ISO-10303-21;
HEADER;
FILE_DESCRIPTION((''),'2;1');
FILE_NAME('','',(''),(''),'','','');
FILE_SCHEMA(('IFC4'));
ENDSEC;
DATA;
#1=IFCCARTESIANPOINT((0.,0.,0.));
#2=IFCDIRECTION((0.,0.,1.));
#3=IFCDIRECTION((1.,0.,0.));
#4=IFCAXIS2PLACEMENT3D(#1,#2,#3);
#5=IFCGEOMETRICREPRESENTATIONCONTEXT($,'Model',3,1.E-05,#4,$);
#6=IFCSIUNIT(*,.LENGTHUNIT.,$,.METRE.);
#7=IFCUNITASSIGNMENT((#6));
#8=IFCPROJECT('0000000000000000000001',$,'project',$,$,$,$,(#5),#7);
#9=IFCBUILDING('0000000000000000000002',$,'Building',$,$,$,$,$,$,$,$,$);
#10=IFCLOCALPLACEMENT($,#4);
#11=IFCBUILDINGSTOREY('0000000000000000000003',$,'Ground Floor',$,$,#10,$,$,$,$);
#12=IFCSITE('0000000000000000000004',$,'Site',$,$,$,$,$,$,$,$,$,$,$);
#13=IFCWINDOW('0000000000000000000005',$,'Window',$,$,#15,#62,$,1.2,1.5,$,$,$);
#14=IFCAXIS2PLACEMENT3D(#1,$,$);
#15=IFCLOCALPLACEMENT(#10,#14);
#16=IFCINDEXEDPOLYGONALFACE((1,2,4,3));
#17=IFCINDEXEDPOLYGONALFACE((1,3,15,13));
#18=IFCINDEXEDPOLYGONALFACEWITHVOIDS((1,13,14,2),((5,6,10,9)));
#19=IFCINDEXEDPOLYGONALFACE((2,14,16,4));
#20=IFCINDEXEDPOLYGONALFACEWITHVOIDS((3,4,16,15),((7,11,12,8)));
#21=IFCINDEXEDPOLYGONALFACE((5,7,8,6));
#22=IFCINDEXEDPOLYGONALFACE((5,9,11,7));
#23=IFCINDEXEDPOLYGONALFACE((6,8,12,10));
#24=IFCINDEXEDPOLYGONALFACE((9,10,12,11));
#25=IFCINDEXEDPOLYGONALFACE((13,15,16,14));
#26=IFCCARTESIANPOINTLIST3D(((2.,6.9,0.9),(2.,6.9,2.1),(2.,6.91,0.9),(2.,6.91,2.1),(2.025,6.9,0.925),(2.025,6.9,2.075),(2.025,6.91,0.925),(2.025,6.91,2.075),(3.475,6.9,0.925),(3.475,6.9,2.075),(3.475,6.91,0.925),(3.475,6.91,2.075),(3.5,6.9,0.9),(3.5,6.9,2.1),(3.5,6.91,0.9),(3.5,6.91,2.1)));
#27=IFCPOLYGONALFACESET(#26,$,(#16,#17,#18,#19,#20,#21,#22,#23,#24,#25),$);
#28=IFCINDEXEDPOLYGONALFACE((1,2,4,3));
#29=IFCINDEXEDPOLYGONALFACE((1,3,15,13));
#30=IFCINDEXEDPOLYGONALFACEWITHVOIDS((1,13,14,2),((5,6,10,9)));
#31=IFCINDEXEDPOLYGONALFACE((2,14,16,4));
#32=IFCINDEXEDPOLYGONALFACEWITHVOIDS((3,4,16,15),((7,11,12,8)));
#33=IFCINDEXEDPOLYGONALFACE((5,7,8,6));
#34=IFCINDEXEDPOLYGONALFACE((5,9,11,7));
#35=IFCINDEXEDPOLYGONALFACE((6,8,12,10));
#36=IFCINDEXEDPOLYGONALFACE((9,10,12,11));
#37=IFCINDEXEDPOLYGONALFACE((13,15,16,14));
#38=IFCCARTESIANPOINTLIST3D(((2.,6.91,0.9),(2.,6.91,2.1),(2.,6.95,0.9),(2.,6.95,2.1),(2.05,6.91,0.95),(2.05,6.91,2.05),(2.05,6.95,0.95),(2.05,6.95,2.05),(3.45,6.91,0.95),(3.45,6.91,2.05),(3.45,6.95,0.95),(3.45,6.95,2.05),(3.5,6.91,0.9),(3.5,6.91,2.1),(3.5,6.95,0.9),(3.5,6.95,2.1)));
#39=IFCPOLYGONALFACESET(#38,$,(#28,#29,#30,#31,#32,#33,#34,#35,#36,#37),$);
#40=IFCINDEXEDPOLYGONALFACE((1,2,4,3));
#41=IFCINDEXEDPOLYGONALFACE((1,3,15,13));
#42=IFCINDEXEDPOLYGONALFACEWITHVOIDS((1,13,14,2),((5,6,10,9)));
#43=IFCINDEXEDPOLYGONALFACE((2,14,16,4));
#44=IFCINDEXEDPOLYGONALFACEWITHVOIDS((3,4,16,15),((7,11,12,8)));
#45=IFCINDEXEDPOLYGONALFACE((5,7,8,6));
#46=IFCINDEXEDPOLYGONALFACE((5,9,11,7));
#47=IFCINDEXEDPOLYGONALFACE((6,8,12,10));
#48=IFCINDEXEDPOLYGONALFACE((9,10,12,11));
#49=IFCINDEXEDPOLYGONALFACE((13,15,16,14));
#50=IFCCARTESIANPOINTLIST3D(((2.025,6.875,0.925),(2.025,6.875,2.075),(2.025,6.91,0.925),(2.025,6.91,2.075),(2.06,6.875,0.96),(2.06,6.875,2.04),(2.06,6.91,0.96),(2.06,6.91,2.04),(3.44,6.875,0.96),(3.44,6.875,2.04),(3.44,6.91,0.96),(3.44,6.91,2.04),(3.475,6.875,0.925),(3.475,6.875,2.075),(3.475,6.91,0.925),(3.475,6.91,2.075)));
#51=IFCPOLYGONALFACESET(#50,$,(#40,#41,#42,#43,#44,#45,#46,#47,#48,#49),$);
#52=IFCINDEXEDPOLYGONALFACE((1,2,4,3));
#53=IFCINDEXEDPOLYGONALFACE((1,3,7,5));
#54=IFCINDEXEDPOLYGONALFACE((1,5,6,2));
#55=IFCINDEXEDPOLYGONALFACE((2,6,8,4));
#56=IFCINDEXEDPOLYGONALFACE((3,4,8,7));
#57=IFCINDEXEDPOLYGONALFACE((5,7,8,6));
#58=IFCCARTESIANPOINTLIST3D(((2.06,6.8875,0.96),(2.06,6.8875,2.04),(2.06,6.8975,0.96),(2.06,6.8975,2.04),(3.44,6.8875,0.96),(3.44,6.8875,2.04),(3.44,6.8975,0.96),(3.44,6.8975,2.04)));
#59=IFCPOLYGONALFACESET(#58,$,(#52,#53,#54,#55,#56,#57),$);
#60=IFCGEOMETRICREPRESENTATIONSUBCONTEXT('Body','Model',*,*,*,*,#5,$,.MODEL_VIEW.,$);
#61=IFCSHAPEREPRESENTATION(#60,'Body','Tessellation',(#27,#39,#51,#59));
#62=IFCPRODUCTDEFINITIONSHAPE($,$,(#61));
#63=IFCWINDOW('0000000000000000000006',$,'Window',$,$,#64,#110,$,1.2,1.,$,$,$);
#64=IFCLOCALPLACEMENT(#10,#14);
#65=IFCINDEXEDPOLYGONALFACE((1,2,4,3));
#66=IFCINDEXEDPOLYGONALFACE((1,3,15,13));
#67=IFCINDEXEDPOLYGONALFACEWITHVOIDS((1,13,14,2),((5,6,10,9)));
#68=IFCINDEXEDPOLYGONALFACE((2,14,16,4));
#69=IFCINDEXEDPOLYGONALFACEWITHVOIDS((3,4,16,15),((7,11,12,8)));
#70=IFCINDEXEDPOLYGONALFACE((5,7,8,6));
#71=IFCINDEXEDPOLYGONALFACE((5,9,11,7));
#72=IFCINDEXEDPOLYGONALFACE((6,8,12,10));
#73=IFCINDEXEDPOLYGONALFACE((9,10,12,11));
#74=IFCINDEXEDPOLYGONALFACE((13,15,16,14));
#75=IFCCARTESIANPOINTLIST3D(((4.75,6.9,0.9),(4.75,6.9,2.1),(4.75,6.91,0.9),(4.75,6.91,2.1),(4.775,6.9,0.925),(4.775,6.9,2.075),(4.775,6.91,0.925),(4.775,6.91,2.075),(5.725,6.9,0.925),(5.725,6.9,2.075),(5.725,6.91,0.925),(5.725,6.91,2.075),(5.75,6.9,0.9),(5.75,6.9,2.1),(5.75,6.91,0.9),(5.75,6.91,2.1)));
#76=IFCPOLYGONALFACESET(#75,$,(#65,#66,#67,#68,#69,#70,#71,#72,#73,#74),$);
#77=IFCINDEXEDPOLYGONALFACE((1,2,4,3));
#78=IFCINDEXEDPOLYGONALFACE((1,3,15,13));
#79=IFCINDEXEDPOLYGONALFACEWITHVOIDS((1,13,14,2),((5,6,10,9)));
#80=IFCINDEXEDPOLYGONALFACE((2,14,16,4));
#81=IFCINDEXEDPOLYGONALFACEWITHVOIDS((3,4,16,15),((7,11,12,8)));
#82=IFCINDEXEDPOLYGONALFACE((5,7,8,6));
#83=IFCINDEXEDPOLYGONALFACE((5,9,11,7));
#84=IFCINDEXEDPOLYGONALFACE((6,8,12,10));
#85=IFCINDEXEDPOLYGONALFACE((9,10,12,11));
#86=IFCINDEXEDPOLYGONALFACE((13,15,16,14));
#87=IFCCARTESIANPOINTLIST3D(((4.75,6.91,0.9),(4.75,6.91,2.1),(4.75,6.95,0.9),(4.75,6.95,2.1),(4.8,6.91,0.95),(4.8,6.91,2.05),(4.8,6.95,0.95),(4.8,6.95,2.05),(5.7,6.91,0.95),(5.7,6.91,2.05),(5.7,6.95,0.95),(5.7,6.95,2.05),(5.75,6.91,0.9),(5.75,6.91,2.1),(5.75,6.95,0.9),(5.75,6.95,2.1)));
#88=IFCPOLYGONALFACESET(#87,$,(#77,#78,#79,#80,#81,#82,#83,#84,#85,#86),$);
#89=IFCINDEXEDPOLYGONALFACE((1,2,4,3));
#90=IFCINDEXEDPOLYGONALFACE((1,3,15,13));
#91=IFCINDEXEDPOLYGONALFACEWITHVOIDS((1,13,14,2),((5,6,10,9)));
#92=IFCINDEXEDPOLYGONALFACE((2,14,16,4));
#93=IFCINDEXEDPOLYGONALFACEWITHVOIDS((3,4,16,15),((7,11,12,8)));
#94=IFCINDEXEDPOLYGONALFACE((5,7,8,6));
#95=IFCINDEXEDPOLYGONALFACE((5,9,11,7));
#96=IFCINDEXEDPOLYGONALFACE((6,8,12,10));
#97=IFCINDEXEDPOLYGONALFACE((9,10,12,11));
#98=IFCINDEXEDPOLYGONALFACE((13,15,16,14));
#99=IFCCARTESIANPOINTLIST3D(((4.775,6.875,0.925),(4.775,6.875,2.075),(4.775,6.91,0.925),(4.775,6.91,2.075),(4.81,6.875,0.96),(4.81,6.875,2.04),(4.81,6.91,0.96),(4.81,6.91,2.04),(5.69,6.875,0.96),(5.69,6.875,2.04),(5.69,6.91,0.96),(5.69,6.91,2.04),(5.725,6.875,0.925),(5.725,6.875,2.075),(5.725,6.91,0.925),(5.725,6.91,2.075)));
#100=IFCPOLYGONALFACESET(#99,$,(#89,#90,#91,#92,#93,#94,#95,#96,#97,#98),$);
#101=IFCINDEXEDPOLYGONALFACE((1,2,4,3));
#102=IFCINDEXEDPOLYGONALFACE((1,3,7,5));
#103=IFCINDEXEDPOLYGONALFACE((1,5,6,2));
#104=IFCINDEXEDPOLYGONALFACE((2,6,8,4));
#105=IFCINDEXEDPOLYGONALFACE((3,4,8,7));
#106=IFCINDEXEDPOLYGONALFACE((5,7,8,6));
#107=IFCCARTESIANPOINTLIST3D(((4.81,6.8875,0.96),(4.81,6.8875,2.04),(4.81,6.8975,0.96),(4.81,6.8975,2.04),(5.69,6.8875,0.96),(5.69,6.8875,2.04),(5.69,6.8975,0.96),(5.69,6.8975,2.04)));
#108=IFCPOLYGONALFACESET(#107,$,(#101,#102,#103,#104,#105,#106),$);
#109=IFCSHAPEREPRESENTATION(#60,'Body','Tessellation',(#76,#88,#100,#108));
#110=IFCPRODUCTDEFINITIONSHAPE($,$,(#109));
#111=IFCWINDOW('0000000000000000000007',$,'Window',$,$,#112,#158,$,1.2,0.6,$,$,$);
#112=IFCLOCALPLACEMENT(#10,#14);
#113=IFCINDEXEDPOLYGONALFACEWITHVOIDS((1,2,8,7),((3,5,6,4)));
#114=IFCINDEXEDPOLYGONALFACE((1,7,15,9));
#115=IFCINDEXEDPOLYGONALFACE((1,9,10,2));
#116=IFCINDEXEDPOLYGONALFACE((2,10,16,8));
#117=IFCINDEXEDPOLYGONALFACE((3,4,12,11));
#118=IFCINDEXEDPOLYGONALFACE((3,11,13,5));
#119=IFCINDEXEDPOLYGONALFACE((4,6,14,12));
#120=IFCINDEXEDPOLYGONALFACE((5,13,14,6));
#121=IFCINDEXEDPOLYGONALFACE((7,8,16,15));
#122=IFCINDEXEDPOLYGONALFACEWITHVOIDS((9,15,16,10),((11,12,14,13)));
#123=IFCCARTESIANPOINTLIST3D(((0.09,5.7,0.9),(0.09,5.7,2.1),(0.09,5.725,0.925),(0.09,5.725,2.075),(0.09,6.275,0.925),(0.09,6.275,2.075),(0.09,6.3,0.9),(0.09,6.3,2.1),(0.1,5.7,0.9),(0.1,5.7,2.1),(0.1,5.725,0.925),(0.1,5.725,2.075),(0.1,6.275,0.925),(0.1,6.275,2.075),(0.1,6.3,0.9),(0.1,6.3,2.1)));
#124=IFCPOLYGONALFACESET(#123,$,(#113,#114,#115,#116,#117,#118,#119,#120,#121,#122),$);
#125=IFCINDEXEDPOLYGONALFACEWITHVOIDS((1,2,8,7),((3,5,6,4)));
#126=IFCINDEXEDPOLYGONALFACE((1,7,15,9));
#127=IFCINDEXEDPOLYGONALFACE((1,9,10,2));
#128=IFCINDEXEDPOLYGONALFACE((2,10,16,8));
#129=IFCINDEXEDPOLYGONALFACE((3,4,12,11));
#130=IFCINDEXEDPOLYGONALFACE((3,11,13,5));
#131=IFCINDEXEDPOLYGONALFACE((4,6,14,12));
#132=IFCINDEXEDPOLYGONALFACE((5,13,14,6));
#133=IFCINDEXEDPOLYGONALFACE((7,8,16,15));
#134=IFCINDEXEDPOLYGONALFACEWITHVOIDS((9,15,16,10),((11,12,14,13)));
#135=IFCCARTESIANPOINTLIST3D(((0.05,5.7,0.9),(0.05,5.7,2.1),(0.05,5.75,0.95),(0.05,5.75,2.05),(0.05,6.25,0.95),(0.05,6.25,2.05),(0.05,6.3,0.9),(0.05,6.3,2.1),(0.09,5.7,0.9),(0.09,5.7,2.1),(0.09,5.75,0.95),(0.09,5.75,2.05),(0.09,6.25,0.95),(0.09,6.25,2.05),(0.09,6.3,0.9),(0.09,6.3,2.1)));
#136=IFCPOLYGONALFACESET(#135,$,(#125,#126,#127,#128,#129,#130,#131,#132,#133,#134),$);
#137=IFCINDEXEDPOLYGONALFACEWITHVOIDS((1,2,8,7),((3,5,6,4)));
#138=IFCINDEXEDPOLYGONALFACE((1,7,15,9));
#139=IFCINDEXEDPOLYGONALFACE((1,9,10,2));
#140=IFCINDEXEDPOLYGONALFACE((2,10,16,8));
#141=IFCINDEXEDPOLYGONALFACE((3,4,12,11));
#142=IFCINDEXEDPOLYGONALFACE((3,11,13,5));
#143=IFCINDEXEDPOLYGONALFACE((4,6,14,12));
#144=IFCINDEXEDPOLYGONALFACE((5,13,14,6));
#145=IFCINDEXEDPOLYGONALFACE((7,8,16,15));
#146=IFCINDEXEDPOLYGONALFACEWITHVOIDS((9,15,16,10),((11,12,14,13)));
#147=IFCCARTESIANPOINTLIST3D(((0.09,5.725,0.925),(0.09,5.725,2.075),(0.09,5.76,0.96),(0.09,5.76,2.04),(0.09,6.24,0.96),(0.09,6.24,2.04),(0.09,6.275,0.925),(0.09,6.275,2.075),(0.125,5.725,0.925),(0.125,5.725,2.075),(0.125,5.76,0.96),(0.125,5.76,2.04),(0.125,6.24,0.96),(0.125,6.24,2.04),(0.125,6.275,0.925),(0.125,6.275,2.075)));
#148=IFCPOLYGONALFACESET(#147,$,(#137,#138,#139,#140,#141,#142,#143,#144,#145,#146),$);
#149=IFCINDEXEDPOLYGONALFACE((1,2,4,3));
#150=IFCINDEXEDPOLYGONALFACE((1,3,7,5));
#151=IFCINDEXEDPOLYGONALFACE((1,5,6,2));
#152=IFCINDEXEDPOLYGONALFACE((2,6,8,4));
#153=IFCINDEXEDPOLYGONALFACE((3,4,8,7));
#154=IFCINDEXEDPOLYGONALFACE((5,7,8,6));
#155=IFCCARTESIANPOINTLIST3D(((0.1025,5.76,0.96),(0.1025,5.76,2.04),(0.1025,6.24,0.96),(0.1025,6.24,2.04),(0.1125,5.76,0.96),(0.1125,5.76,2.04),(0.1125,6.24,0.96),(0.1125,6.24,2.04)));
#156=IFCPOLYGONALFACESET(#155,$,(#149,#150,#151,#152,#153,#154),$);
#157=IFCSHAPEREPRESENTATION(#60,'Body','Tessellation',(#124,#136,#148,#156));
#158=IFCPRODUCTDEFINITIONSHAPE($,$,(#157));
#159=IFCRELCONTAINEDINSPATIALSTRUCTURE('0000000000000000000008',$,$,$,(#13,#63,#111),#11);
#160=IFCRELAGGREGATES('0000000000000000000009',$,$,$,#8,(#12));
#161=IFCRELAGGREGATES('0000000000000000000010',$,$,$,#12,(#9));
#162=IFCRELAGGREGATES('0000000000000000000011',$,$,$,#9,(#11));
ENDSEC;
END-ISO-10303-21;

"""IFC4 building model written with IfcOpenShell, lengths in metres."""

from ifc_helpers import new_model, si_unit, frame, origin_with_axes, place, context, subcontext, project, spatial, line, indexed_curve, outline, extrude, element, save


model = new_model("IFC4")

# Units and contexts
model_context = context("Model", 3, precision=1e-05, world=origin_with_axes())
body_context = subcontext(model_context, "Body", "Model", "MODEL_VIEW")
ifc_project = project(units=[si_unit("LENGTHUNIT", "METRE")], contexts=[model_context])

# Site, building, storey
site = spatial("IfcSite", under=ifc_project, Name="Site")
building = spatial("IfcBuilding", under=site, Name="Building")
storey_placement = place(None, origin_with_axes())
storey = spatial("IfcBuildingStorey", under=building, at=storey_placement, Name="Ground Floor")

# Windows
window_1_placement = place(storey_placement, frame((3.5, 7.0, 0.9), z_axis=(0.0, 0.0, 1.0), x_axis=(-1.0, 0.0, 0.0)))
element("IfcWindow", 1, at=window_1_placement, inside=storey, Name="Window", OverallHeight=1.2, OverallWidth=1.5, context=body_context, shape_type="SweptSolid", body=[
    extrude(outline(indexed_curve([(0.0, 0.0), (1.5, 0.0), (1.5, 1.2), (0.0, 1.2)], segments=[line(1, 2, 3, 4, 1)]), holes=[indexed_curve([(0.025, 0.025), (1.475, 0.025), (1.475, 1.175), (0.025, 1.175)], segments=[line(1, 2, 3, 4, 1)])]), frame((0.0, 0.09, 0.0), z_axis=(0.0, -1.0, 0.0), x_axis=(1.0, 0.0, 0.0)), (0.0, 0.0, -1.0), 0.01),
    extrude(outline(indexed_curve([(0.0, 0.0), (1.5, 0.0), (1.5, 1.2), (0.0, 1.2)], segments=[line(1, 2, 3, 4, 1)]), holes=[indexed_curve([(0.05, 0.05), (1.45, 0.05), (1.45, 1.15), (0.05, 1.15)], segments=[line(1, 2, 3, 4, 1)])]), frame((0.0, 0.05, 0.0), z_axis=(0.0, -1.0, 0.0), x_axis=(1.0, 0.0, 0.0)), (0.0, 0.0, -1.0), 0.04),
    extrude(outline(indexed_curve([(0.0, 0.0), (1.45, 0.0), (1.45, 1.15), (0.0, 1.15)], segments=[line(1, 2, 3, 4, 1)]), holes=[indexed_curve([(0.035, 0.035), (1.415, 0.035), (1.415, 1.115), (0.035, 1.115)], segments=[line(1, 2, 3, 4, 1)])]), frame((0.025, 0.09, 0.025), z_axis=(0.0, -1.0, 0.0), x_axis=(1.0, 0.0, 0.0)), (0.0, 0.0, -1.0), 0.035),
    extrude(outline(indexed_curve([(0.035, 0.035), (1.415, 0.035), (1.415, 1.115), (0.035, 1.115)], segments=[line(1, 2, 3, 4, 1)])), frame((0.025, 0.1025, 0.025), z_axis=(0.0, -1.0, 0.0), x_axis=(1.0, 0.0, 0.0)), (0.0, 0.0, -1.0), 0.01),
])
window_2_placement = place(storey_placement, frame((5.75, 7.0, 0.9), z_axis=(0.0, 0.0, 1.0), x_axis=(-1.0, 0.0, 0.0)))
element("IfcWindow", 2, at=window_2_placement, inside=storey, Name="Window", OverallHeight=1.2, OverallWidth=1.0, context=body_context, shape_type="SweptSolid", body=[
    extrude(outline(indexed_curve([(0.0, 0.0), (1.0, 0.0), (1.0, 1.2), (0.0, 1.2)], segments=[line(1, 2, 3, 4, 1)]), holes=[indexed_curve([(0.025, 0.025), (0.975, 0.025), (0.975, 1.175), (0.025, 1.175)], segments=[line(1, 2, 3, 4, 1)])]), frame((0.0, 0.09, 0.0), z_axis=(0.0, -1.0, 0.0), x_axis=(1.0, 0.0, 0.0)), (0.0, 0.0, -1.0), 0.01),
    extrude(outline(indexed_curve([(0.0, 0.0), (1.0, 0.0), (1.0, 1.2), (0.0, 1.2)], segments=[line(1, 2, 3, 4, 1)]), holes=[indexed_curve([(0.05, 0.05), (0.95, 0.05), (0.95, 1.15), (0.05, 1.15)], segments=[line(1, 2, 3, 4, 1)])]), frame((0.0, 0.05, 0.0), z_axis=(0.0, -1.0, 0.0), x_axis=(1.0, 0.0, 0.0)), (0.0, 0.0, -1.0), 0.04),
    extrude(outline(indexed_curve([(0.0, 0.0), (0.95, 0.0), (0.95, 1.15), (0.0, 1.15)], segments=[line(1, 2, 3, 4, 1)]), holes=[indexed_curve([(0.035, 0.035), (0.915, 0.035), (0.915, 1.115), (0.035, 1.115)], segments=[line(1, 2, 3, 4, 1)])]), frame((0.025, 0.09, 0.025), z_axis=(0.0, -1.0, 0.0), x_axis=(1.0, 0.0, 0.0)), (0.0, 0.0, -1.0), 0.035),
    extrude(outline(indexed_curve([(0.035, 0.035), (0.915, 0.035), (0.915, 1.115), (0.035, 1.115)], segments=[line(1, 2, 3, 4, 1)])), frame((0.025, 0.1025, 0.025), z_axis=(0.0, -1.0, 0.0), x_axis=(1.0, 0.0, 0.0)), (0.0, 0.0, -1.0), 0.01),
])
window_3_placement = place(storey_placement, frame((0.0, 6.3, 0.9), z_axis=(0.0, 0.0, 1.0), x_axis=(0.0, -1.0, 0.0)))
element("IfcWindow", 3, at=window_3_placement, inside=storey, Name="Window", OverallHeight=1.2, OverallWidth=0.6, context=body_context, shape_type="SweptSolid", body=[
    extrude(outline(indexed_curve([(0.0, 0.0), (0.6, 0.0), (0.6, 1.2), (0.0, 1.2)], segments=[line(1, 2, 3, 4, 1)]), holes=[indexed_curve([(0.025, 0.025), (0.575, 0.025), (0.575, 1.175), (0.025, 1.175)], segments=[line(1, 2, 3, 4, 1)])]), frame((0.0, 0.09, 0.0), z_axis=(0.0, -1.0, 0.0), x_axis=(1.0, 0.0, 0.0)), (0.0, 0.0, -1.0), 0.01),
    extrude(outline(indexed_curve([(0.0, 0.0), (0.6, 0.0), (0.6, 1.2), (0.0, 1.2)], segments=[line(1, 2, 3, 4, 1)]), holes=[indexed_curve([(0.05, 0.05), (0.55, 0.05), (0.55, 1.15), (0.05, 1.15)], segments=[line(1, 2, 3, 4, 1)])]), frame((0.0, 0.05, 0.0), z_axis=(0.0, -1.0, 0.0), x_axis=(1.0, 0.0, 0.0)), (0.0, 0.0, -1.0), 0.04),
    extrude(outline(indexed_curve([(0.0, 0.0), (0.55, 0.0), (0.55, 1.15), (0.0, 1.15)], segments=[line(1, 2, 3, 4, 1)]), holes=[indexed_curve([(0.035, 0.035), (0.515, 0.035), (0.515, 1.115), (0.035, 1.115)], segments=[line(1, 2, 3, 4, 1)])]), frame((0.025, 0.09, 0.025), z_axis=(0.0, -1.0, 0.0), x_axis=(1.0, 0.0, 0.0)), (0.0, 0.0, -1.0), 0.035),
    extrude(outline(indexed_curve([(0.035, 0.035), (0.515, 0.035), (0.515, 1.115), (0.035, 1.115)], segments=[line(1, 2, 3, 4, 1)])), frame((0.025, 0.1025, 0.025), z_axis=(0.0, -1.0, 0.0), x_axis=(1.0, 0.0, 0.0)), (0.0, 0.0, -1.0), 0.01),
])

save(model, "model.ifc")
